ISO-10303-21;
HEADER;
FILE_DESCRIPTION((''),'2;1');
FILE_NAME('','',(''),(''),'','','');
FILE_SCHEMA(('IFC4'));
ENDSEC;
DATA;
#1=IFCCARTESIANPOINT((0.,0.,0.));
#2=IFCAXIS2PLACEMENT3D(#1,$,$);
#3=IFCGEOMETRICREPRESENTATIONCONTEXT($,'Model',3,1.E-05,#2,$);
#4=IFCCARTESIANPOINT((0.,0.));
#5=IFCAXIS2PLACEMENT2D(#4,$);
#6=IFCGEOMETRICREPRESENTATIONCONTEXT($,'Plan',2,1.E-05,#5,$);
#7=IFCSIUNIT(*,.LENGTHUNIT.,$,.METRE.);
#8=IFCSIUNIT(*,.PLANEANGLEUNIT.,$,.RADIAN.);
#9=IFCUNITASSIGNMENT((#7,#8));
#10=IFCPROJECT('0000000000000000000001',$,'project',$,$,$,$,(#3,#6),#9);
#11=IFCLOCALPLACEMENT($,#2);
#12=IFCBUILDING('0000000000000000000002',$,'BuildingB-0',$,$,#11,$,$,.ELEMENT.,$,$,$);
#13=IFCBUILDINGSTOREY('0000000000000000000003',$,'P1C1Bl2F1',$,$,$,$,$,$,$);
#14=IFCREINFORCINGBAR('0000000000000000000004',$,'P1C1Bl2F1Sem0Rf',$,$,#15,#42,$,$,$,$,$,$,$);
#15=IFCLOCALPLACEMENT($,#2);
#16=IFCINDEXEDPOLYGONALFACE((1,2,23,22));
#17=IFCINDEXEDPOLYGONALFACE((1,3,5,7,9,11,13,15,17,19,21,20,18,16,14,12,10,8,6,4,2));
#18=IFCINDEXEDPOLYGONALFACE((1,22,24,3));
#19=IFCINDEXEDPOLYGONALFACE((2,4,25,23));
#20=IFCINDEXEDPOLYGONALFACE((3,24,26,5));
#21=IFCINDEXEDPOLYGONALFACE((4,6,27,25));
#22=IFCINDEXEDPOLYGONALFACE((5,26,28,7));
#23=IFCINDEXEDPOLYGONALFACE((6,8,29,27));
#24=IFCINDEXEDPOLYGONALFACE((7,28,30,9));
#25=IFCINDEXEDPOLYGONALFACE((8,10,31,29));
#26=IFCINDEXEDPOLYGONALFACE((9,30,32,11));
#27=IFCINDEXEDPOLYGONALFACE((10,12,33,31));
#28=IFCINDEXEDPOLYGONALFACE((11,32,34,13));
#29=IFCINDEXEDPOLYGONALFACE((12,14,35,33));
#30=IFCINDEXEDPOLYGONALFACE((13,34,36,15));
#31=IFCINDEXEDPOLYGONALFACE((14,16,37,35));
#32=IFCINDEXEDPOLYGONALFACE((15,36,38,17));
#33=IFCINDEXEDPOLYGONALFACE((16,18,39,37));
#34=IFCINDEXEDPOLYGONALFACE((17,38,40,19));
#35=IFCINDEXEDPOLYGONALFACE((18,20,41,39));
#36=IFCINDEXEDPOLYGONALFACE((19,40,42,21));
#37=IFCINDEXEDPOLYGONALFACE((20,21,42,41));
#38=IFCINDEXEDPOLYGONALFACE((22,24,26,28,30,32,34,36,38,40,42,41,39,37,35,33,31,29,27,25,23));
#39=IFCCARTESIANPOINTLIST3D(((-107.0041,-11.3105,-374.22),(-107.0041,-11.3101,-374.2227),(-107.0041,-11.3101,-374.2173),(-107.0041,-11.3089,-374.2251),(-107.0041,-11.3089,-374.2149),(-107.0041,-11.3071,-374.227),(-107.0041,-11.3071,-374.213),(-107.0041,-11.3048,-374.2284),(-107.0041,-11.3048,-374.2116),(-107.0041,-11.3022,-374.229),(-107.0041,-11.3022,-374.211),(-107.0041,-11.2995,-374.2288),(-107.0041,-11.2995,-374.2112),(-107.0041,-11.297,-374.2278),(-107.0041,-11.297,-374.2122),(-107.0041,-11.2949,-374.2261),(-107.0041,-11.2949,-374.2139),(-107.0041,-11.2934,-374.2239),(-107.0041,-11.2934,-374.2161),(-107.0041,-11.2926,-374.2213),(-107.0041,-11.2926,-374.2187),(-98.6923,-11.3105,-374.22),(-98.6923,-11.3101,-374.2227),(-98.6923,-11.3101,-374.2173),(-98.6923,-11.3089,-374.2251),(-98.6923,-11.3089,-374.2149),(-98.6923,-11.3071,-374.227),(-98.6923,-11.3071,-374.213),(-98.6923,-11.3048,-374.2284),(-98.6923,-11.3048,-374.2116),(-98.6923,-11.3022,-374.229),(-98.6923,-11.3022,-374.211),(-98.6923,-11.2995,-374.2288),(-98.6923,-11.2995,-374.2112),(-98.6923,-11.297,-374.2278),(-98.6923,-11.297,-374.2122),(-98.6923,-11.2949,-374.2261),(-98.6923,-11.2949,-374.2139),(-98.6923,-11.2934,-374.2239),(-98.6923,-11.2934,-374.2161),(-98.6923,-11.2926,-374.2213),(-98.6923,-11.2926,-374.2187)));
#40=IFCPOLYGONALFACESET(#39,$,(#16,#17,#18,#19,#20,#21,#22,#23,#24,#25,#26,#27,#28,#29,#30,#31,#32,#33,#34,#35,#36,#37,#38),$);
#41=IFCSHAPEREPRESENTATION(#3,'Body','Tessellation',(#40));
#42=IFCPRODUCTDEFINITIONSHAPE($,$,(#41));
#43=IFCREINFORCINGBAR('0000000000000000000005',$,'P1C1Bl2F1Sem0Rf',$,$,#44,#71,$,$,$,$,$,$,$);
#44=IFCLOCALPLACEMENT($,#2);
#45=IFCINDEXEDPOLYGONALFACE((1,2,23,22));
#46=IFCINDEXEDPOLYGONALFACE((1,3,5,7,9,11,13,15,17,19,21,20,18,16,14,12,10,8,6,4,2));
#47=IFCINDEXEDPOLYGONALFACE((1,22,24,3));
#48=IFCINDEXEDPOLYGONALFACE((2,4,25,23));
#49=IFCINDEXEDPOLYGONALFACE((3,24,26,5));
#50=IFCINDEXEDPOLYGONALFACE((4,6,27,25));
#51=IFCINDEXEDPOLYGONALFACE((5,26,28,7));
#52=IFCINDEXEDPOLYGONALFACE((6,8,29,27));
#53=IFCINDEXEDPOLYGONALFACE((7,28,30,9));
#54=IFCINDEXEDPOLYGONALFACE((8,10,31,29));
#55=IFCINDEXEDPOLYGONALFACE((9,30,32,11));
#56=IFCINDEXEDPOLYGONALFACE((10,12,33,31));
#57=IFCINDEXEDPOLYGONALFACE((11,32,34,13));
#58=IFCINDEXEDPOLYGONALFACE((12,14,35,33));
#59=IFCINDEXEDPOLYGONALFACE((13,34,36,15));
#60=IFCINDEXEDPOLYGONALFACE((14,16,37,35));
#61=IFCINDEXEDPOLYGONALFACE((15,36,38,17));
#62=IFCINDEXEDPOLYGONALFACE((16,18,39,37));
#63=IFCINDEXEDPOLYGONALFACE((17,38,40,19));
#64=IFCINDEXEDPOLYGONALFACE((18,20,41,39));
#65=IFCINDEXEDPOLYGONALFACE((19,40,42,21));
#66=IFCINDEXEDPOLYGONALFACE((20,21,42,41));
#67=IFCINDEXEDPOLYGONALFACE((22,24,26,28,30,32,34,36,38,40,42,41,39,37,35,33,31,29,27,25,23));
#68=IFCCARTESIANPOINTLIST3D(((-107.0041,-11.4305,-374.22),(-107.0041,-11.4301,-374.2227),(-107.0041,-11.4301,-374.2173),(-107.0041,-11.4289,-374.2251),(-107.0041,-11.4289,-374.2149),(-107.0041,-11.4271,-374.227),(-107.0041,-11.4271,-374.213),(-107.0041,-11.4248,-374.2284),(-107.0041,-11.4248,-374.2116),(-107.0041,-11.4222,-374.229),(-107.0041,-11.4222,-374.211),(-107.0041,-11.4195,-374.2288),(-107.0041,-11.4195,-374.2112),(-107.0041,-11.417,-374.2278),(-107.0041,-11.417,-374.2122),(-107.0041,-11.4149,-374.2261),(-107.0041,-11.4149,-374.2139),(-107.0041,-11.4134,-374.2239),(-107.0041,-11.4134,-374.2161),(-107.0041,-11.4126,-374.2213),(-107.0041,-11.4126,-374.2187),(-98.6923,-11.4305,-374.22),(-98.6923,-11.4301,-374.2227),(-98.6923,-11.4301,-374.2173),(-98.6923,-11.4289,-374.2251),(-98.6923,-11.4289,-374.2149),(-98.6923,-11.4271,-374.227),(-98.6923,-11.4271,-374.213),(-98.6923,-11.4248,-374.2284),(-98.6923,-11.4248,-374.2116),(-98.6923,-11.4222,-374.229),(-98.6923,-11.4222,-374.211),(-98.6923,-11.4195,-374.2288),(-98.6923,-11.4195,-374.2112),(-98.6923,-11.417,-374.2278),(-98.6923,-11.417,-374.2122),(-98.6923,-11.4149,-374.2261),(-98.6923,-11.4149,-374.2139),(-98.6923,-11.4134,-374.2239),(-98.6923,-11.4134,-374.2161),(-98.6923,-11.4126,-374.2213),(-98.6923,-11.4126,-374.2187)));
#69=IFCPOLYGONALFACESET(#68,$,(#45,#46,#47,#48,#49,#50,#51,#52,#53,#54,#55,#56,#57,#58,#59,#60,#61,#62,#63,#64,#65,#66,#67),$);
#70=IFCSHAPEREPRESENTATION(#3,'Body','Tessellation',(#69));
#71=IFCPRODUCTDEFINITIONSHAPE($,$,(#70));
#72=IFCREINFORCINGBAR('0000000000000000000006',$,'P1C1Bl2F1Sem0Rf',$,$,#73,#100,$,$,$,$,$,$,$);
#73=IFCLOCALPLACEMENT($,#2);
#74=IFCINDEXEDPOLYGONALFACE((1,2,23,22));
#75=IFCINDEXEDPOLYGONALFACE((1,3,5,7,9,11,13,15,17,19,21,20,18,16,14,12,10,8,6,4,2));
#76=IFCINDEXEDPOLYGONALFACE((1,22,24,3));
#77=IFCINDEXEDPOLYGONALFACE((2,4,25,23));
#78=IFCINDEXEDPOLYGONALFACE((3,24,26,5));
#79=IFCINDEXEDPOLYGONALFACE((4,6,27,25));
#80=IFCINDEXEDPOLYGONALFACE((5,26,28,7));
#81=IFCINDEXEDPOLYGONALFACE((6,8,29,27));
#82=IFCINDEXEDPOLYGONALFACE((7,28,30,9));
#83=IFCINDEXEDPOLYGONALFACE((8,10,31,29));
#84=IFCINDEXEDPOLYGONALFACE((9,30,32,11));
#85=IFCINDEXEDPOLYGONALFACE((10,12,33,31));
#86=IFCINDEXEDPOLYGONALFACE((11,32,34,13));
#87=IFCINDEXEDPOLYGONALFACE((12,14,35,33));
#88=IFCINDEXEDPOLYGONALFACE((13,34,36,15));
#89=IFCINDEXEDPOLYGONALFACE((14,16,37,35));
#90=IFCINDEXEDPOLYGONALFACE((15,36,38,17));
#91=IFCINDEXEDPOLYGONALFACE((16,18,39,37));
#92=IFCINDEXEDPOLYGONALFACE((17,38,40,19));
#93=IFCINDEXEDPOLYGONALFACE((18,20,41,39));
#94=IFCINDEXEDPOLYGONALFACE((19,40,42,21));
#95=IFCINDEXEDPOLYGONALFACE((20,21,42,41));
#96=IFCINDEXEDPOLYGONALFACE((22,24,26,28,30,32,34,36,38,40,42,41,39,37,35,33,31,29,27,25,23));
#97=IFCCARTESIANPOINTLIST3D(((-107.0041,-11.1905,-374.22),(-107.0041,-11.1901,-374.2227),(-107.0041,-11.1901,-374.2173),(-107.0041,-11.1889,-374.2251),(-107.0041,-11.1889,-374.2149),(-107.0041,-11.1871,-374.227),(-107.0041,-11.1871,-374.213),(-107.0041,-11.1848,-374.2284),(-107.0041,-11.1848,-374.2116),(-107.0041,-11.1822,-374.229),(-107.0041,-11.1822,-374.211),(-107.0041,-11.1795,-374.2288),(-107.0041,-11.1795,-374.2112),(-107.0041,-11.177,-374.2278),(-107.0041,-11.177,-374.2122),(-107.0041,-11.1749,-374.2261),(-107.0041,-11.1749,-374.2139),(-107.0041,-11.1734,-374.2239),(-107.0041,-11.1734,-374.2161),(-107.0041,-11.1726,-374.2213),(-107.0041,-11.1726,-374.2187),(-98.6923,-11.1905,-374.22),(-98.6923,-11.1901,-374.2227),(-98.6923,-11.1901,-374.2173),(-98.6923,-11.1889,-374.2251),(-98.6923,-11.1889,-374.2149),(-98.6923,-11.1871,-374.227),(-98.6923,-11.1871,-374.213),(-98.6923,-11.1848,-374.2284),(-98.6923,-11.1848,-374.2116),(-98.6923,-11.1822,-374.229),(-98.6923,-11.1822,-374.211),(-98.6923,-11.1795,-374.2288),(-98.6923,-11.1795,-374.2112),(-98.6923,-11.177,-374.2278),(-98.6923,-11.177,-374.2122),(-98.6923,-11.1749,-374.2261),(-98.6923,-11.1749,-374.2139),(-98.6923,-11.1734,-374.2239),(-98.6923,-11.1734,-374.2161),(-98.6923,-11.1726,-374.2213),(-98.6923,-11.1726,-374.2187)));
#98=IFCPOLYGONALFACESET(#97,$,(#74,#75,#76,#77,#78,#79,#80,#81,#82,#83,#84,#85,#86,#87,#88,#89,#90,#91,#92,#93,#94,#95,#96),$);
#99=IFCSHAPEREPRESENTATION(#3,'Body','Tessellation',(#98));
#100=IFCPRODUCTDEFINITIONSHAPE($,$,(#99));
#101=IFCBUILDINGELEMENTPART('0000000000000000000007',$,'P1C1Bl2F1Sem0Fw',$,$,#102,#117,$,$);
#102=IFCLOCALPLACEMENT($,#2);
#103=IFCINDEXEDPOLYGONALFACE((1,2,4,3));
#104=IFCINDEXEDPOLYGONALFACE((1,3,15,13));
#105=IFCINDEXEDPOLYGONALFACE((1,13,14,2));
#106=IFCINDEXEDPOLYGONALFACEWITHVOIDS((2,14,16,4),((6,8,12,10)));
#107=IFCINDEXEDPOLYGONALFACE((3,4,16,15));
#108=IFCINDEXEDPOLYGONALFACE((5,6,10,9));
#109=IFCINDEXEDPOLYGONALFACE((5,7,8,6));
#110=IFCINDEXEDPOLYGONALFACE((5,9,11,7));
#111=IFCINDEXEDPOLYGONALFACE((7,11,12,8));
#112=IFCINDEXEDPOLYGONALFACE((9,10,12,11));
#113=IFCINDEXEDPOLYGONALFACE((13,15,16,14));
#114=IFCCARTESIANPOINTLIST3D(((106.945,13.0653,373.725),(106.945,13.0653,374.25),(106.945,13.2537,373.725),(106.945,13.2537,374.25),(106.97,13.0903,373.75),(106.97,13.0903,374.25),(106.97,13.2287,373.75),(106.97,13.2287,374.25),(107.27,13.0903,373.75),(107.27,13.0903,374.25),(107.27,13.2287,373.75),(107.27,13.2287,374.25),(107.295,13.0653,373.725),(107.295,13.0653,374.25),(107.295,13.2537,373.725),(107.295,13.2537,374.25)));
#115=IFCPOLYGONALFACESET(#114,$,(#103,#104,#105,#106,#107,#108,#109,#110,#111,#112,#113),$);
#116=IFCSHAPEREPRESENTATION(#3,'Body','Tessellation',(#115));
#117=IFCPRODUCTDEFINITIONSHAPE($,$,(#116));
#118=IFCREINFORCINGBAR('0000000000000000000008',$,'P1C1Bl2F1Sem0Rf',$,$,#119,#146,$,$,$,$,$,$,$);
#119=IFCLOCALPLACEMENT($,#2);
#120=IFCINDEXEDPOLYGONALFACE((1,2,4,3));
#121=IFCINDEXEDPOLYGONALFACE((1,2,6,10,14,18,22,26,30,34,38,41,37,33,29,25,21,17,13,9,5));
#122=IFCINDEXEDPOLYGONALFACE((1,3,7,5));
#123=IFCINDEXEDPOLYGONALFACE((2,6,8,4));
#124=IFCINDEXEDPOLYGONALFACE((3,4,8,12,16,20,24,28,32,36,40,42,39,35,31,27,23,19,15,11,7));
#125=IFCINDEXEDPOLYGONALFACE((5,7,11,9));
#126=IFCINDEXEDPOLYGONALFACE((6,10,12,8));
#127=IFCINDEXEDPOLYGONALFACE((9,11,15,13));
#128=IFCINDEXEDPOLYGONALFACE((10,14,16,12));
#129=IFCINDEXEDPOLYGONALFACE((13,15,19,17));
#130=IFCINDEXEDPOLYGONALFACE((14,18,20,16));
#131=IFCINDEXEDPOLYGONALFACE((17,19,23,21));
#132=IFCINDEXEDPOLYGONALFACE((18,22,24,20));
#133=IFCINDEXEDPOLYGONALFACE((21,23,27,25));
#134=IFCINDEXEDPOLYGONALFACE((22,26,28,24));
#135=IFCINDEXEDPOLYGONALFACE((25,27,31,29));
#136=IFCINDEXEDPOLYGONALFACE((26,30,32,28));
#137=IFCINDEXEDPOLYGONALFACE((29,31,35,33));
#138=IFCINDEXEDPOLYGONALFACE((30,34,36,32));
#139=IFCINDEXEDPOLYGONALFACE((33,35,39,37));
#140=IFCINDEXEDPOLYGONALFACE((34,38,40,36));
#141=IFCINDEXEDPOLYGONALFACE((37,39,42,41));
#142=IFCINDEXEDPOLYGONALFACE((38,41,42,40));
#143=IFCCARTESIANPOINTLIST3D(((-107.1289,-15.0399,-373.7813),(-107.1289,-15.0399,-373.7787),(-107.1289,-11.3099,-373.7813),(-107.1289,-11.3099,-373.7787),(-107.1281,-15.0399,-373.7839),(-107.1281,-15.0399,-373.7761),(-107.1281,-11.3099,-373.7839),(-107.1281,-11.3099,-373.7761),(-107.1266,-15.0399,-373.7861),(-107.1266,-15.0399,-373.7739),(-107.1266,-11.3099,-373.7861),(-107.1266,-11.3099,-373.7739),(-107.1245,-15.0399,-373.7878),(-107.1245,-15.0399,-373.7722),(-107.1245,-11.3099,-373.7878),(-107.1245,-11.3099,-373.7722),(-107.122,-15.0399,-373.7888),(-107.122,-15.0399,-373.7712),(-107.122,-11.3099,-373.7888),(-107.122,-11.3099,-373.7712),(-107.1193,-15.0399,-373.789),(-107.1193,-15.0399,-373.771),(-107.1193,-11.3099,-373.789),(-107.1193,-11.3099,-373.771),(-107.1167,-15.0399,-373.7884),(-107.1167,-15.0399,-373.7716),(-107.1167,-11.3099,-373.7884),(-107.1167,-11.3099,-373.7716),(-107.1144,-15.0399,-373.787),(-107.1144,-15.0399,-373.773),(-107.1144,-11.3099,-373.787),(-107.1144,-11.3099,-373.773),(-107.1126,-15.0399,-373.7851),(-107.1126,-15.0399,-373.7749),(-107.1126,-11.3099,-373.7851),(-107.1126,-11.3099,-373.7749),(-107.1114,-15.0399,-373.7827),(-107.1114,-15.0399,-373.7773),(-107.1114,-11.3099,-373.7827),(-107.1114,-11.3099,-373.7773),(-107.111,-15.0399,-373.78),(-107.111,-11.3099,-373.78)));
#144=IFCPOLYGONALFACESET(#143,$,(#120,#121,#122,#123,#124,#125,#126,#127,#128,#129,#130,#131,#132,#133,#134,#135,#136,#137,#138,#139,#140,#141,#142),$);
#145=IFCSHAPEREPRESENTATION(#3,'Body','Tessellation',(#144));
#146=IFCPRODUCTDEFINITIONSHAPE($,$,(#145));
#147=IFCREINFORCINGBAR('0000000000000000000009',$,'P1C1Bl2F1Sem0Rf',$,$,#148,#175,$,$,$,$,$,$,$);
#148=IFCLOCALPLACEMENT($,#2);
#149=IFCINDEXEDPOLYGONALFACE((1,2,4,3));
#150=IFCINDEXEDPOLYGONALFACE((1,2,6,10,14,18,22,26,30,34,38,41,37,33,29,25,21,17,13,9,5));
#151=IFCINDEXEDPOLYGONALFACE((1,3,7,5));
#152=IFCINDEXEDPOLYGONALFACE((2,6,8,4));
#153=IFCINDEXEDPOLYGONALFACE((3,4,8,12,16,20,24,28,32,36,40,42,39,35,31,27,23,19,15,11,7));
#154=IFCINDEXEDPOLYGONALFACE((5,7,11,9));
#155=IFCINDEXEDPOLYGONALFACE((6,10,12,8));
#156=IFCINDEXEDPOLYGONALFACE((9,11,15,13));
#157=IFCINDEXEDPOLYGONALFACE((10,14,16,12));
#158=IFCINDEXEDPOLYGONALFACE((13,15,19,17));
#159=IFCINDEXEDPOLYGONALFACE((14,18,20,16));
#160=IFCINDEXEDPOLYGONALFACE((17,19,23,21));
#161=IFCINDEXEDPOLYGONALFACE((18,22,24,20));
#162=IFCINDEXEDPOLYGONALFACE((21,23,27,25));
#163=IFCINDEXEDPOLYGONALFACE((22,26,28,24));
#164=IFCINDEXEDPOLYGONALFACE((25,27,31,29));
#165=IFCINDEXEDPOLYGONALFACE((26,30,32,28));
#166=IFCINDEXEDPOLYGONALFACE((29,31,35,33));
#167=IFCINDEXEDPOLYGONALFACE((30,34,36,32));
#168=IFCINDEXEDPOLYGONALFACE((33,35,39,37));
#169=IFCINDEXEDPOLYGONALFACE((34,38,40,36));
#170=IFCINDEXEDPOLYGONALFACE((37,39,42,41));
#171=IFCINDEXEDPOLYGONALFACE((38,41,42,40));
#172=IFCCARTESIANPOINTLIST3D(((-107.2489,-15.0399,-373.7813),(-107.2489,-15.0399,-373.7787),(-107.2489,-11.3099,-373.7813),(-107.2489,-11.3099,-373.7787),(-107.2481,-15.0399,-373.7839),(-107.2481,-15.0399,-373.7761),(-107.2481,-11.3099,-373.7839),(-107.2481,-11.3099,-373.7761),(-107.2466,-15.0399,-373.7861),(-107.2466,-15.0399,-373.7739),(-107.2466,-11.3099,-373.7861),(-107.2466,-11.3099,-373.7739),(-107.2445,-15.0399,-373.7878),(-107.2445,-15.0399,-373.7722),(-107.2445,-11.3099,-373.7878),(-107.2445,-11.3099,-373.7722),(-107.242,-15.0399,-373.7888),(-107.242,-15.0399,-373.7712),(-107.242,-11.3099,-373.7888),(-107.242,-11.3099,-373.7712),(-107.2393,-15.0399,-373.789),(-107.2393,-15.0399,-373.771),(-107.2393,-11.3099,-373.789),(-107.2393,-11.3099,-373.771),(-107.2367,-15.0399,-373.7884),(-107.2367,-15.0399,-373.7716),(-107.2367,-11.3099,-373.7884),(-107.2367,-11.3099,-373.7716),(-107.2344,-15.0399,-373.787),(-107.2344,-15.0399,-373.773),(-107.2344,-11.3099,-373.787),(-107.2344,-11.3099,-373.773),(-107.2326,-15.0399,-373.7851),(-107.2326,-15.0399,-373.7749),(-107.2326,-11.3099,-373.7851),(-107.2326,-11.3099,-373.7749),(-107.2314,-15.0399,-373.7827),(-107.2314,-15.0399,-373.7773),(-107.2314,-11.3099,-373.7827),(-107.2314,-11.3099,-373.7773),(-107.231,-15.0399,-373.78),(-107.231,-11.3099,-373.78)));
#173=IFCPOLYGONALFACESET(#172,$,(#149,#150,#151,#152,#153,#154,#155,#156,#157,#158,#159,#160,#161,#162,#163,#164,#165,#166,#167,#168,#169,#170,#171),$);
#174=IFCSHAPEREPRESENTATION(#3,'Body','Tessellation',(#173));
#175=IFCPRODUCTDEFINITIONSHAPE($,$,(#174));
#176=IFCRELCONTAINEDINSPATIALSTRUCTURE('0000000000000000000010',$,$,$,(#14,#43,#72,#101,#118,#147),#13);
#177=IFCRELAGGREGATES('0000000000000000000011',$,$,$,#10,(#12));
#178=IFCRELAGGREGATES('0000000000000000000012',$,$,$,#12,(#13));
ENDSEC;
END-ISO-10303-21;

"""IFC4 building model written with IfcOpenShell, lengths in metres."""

from ifc_helpers import new_model, entity, si_unit, origin, origin_2d, place, context, project, spatial, polyline, outline, extrude, element, save


model = new_model("IFC4")

# Units and contexts
model_context = context("Model", 3, precision=1e-05, world=origin())
plan_context = context("Plan", 2, precision=1e-05, world=origin_2d())
ifc_project = project(units=[si_unit("LENGTHUNIT", "METRE"), si_unit("PLANEANGLEUNIT", "RADIAN")], contexts=[model_context, plan_context])

# Building, storey
building_placement = place(None, origin())
building = spatial("IfcBuilding", under=ifc_project, at=building_placement, Name="BuildingB-0", CompositionType="ELEMENT")
storey = spatial("IfcBuildingStorey", under=building, Name="P1C1Bl2F1")

# Reinforcing bars
element("IfcReinforcingBar", 1, inside=storey, Name="P1C1Bl2F1Sem0Rf", context=model_context, shape_type="SweptSolid", body=[
    entity("IfcSurfaceCurveSweptAreaSolid", entity("IfcCircleProfileDef", "AREA", None, None, 0.009), None, entity("IfcPolyline", [entity("IfcCartesianPoint", [107.0041, 11.3015, 374.22]), entity("IfcCartesianPoint", [98.6923, 11.3015, 374.22])]), None, None, entity("IfcPlane", entity("IfcAxis2Placement3D", entity("IfcCartesianPoint", [107.0041, 11.3015, 374.22]), entity("IfcDirection", [0.0, 0.0, 1.0]), entity("IfcDirection", [1.0, 0.0, 0.0])))),
])
element("IfcReinforcingBar", 2, inside=storey, Name="P1C1Bl2F1Sem0Rf", context=model_context, shape_type="SweptSolid", body=[
    entity("IfcSurfaceCurveSweptAreaSolid", entity("IfcCircleProfileDef", "AREA", None, None, 0.009), None, entity("IfcPolyline", [entity("IfcCartesianPoint", [107.0041, 11.4215, 374.22]), entity("IfcCartesianPoint", [98.6923, 11.4215, 374.22])]), None, None, entity("IfcPlane", entity("IfcAxis2Placement3D", entity("IfcCartesianPoint", [107.0041, 11.4215, 374.22]), entity("IfcDirection", [0.0, 0.0, 1.0]), entity("IfcDirection", [1.0, 0.0, 0.0])))),
])
element("IfcReinforcingBar", 3, inside=storey, Name="P1C1Bl2F1Sem0Rf", context=model_context, shape_type="SweptSolid", body=[
    entity("IfcSurfaceCurveSweptAreaSolid", entity("IfcCircleProfileDef", "AREA", None, None, 0.009), None, entity("IfcPolyline", [entity("IfcCartesianPoint", [107.0041, 11.1815, 374.22]), entity("IfcCartesianPoint", [98.6923, 11.1815, 374.22])]), None, None, entity("IfcPlane", entity("IfcAxis2Placement3D", entity("IfcCartesianPoint", [107.0041, 11.1815, 374.22]), entity("IfcDirection", [0.0, 0.0, 1.0]), entity("IfcDirection", [1.0, 0.0, 0.0])))),
])

# Building element part, opening
building_element_part_1 = element("IfcBuildingElementPart", 4, inside=storey, Name="P1C1Bl2F1Sem0Fw", context=model_context, shape_type="SweptSolid", body=[
    extrude(outline(polyline([(107.295, 13.0653, 373.725), (107.295, 13.2537, 373.725), (106.945, 13.2537, 373.725), (106.945, 13.0653, 373.725), (107.295, 13.0653, 373.725)])), None, (0.0, 0.0, 1.0), 0.525),
])
element("IfcOpeningElement", 5, inside=storey, cuts=building_element_part_1, context=model_context, shape_type="SweptSolid", body=[
    extrude(outline(polyline([(107.27, 13.0903, 373.75), (107.27, 13.2287, 373.75), (106.97, 13.2287, 373.75), (106.97, 13.0903, 373.75), (107.27, 13.0903, 373.75)])), None, (0.0, 0.0, 1.0), 0.5),
])

# Reinforcing bars
element("IfcReinforcingBar", 6, inside=storey, Name="P1C1Bl2F1Sem0Rf", context=model_context, shape_type="SweptSolid", body=[
    entity("IfcSurfaceCurveSweptAreaSolid", entity("IfcCircleProfileDef", "AREA", None, None, 0.009), None, entity("IfcPolyline", [entity("IfcCartesianPoint", [107.12, 11.3099, 373.78]), entity("IfcCartesianPoint", [107.12, 15.0399, 373.78])]), None, None, entity("IfcPlane", entity("IfcAxis2Placement3D", entity("IfcCartesianPoint", [107.12, 11.3099, 373.78]), entity("IfcDirection", [0.0, 0.0, 1.0]), entity("IfcDirection", [1.0, 0.0, 0.0])))),
])
element("IfcReinforcingBar", 7, inside=storey, Name="P1C1Bl2F1Sem0Rf", context=model_context, shape_type="SweptSolid", body=[
    entity("IfcSurfaceCurveSweptAreaSolid", entity("IfcCircleProfileDef", "AREA", None, None, 0.009), None, entity("IfcPolyline", [entity("IfcCartesianPoint", [107.24, 11.3099, 373.78]), entity("IfcCartesianPoint", [107.24, 15.0399, 373.78])]), None, None, entity("IfcPlane", entity("IfcAxis2Placement3D", entity("IfcCartesianPoint", [107.24, 11.3099, 373.78]), entity("IfcDirection", [0.0, 0.0, 1.0]), entity("IfcDirection", [1.0, 0.0, 0.0])))),
])

save(model, "model.ifc")
